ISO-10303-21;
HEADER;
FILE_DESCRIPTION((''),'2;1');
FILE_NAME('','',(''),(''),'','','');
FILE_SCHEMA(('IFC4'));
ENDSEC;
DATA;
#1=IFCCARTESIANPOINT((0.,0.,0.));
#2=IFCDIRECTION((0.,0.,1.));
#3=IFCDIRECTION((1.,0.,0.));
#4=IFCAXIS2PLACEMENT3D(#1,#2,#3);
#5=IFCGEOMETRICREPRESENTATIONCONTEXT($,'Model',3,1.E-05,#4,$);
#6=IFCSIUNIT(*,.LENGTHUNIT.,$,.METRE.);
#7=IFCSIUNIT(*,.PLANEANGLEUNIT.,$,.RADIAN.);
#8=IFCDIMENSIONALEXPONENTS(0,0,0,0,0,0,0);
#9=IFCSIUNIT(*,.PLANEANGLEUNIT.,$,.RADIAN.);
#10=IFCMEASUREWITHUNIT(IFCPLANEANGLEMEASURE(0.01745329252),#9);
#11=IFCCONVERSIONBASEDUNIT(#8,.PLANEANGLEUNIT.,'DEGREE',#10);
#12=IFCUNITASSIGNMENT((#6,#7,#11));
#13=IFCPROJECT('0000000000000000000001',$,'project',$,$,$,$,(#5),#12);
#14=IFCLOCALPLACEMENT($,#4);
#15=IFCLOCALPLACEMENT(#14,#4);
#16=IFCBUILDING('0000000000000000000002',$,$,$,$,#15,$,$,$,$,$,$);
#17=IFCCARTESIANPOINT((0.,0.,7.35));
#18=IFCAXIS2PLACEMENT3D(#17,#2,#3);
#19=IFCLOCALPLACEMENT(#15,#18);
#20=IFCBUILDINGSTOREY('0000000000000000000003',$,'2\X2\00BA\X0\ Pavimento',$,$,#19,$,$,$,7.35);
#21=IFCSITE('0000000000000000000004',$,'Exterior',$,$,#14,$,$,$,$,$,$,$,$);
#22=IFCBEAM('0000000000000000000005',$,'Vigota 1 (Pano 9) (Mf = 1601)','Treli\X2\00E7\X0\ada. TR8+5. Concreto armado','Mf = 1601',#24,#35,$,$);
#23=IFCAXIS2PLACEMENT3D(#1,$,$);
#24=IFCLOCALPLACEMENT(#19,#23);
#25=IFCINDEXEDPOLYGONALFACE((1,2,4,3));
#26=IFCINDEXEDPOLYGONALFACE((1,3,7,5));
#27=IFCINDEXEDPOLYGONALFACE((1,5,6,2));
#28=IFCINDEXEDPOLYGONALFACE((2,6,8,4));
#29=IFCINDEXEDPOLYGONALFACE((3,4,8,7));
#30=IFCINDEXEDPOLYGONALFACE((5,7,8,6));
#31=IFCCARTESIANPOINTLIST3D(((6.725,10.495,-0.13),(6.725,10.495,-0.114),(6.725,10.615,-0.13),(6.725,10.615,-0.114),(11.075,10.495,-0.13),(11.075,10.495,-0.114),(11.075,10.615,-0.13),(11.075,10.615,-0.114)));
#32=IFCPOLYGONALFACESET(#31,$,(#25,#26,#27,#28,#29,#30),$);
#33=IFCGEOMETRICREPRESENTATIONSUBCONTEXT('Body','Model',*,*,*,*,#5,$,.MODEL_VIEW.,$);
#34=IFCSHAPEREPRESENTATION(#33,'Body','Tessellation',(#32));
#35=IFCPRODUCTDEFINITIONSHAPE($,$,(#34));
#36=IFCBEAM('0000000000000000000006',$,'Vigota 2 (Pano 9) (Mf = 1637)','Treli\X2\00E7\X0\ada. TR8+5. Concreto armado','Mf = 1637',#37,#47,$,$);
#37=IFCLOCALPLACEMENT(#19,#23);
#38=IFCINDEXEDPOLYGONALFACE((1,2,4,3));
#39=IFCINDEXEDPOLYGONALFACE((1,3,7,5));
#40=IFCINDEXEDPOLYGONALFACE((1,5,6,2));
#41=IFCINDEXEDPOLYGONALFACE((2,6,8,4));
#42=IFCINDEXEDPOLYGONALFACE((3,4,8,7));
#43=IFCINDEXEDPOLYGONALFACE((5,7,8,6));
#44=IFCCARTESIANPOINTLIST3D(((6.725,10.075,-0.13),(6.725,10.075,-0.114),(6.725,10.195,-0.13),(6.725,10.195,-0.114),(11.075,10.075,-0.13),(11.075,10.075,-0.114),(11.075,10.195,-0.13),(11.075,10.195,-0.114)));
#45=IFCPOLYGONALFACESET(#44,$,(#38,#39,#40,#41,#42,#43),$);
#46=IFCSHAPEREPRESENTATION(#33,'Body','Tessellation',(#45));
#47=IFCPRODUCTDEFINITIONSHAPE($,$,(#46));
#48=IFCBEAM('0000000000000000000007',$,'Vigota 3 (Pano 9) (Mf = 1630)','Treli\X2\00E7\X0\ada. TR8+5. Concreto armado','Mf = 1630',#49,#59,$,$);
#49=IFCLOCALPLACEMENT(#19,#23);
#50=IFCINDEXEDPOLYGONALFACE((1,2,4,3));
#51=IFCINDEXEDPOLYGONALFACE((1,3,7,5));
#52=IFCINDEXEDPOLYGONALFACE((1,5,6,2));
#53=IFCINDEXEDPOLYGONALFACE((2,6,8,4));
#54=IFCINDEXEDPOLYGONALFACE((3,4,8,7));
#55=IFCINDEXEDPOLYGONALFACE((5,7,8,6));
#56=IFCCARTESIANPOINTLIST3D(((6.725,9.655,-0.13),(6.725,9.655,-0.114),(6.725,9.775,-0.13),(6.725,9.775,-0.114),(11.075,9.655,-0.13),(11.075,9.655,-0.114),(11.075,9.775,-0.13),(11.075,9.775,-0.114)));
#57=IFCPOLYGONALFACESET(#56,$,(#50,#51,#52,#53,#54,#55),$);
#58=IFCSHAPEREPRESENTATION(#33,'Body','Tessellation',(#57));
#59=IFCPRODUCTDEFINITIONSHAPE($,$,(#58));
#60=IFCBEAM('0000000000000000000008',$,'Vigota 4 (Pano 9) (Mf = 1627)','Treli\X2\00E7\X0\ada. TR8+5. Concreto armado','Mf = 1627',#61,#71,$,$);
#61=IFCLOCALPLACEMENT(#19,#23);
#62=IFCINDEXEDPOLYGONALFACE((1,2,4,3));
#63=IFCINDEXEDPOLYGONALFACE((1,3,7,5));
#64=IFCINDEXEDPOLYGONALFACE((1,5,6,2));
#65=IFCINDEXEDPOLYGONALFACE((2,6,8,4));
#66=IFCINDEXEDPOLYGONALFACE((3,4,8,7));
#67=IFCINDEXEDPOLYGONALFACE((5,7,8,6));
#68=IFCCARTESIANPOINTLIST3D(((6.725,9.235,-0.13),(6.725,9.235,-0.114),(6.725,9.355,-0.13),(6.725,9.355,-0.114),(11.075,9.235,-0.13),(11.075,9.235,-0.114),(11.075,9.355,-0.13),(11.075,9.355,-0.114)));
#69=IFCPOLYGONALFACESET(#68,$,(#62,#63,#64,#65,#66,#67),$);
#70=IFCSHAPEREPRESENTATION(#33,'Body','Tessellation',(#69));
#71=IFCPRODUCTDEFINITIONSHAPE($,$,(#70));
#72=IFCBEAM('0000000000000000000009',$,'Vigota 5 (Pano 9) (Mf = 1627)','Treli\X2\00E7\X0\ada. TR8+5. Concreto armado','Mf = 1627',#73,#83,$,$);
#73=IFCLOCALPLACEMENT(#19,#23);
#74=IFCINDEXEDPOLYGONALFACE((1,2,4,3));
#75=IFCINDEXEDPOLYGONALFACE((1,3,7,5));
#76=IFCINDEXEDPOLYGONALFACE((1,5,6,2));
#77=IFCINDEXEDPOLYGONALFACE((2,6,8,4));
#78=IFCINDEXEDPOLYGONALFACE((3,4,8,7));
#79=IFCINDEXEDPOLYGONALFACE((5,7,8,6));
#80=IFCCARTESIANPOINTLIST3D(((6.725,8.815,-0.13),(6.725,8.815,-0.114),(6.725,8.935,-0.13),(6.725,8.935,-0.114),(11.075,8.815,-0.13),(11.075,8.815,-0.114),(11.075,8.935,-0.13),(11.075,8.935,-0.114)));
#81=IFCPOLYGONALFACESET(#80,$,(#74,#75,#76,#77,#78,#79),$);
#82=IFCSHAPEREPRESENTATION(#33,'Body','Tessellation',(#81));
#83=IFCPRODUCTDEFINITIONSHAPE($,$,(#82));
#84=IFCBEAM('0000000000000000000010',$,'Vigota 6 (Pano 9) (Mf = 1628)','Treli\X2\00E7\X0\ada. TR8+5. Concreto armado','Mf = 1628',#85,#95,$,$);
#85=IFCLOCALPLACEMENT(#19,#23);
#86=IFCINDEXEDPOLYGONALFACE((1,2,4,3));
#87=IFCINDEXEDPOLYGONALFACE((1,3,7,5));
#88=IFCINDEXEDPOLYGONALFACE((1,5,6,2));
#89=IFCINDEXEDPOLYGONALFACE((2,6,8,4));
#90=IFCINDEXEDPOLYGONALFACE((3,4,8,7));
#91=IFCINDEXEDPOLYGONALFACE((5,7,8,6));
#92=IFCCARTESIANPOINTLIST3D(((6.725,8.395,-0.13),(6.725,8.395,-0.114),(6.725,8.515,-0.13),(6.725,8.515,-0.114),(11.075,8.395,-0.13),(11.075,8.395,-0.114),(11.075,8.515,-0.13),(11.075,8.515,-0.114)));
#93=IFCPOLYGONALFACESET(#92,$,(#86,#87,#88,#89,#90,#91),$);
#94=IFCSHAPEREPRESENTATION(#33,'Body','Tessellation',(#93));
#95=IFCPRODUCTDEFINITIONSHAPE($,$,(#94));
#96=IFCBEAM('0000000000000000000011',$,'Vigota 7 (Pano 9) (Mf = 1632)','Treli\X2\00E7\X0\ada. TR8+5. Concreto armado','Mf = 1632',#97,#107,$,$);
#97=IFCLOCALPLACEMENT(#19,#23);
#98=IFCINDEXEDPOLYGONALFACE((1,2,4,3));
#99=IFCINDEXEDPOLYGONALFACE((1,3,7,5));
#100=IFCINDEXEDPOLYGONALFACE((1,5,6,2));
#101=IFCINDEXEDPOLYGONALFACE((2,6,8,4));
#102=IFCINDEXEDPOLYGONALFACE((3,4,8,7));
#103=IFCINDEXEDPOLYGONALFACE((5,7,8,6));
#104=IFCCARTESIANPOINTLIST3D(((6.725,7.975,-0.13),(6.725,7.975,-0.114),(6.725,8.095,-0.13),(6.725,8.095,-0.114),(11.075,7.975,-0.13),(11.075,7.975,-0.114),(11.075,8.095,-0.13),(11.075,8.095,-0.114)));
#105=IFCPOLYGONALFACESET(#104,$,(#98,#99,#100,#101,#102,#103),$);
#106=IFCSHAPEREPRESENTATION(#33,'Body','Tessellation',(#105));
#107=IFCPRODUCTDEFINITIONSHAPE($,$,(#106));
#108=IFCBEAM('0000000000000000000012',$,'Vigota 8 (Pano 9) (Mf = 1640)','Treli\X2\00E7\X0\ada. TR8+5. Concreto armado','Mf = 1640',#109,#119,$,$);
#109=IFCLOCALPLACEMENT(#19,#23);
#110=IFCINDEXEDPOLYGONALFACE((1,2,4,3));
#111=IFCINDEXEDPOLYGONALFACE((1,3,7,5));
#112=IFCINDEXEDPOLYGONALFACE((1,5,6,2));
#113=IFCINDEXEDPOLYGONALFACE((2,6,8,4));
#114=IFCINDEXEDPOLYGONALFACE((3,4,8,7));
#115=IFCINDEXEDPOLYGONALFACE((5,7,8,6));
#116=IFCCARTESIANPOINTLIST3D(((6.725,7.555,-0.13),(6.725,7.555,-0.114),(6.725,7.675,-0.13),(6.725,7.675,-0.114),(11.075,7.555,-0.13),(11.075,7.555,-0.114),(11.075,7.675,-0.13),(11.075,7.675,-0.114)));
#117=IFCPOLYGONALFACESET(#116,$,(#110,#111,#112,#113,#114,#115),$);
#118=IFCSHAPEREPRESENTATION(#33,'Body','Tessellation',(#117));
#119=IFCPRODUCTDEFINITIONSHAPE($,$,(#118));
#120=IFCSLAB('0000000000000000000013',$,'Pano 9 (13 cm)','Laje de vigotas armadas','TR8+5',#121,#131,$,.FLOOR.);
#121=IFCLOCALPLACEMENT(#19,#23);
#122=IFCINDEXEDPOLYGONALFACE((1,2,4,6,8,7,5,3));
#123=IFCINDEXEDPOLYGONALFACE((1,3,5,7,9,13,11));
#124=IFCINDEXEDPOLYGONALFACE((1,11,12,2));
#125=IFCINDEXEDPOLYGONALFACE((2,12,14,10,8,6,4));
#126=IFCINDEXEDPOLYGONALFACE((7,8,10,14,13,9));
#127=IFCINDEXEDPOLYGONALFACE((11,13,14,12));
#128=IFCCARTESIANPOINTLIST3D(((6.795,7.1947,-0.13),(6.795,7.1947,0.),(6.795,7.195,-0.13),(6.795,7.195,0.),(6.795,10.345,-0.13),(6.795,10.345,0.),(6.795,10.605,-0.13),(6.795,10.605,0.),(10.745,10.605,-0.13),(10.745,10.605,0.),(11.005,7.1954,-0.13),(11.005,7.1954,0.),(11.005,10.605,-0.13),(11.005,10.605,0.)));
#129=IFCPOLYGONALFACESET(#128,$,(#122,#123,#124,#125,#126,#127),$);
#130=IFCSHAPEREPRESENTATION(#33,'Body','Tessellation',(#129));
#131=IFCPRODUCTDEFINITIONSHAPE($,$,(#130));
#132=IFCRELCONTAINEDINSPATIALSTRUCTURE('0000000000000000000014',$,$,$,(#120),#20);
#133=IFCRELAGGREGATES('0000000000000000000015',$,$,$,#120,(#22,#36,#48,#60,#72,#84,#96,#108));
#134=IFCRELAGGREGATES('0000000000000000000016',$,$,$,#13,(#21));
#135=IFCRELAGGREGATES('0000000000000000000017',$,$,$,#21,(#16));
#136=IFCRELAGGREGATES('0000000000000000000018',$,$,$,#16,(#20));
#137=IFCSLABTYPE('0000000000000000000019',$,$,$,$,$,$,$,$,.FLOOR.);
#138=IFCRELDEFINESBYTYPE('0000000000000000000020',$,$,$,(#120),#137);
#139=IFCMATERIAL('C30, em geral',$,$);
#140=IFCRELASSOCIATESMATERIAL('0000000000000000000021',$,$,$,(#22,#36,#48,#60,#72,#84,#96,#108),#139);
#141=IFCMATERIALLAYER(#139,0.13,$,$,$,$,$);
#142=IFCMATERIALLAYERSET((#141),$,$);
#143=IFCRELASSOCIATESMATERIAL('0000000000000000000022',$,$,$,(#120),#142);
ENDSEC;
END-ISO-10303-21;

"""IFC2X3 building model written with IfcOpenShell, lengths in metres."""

from ifc_helpers import new_model, entity, si_unit, converted_unit, frame, origin_with_axes, place, context, subcontext, project, spatial, polyline, outline, extrude, material, layer, layer_set, layer_usage, type_object, element, aggregate, save


model = new_model("IFC2X3")

# Units and contexts
model_context = context("Model", 3, precision=1e-05, world=origin_with_axes())
body_context = subcontext(model_context, "Body", "Model", "MODEL_VIEW")
ifc_project = project(units=[si_unit("LENGTHUNIT", "METRE"), si_unit("PLANEANGLEUNIT", "RADIAN"), converted_unit("PLANEANGLEUNIT", "DEGREE", entity("IfcPlaneAngleMeasure", 0.01745329252), si_unit("PLANEANGLEUNIT", "RADIAN"), dimensions=[0, 0, 0, 0, 0, 0, 0])], contexts=[model_context])

# Beams
ifc_material = material(Name="C30, em geral")
site_placement = place(None, origin_with_axes())
building_placement = place(site_placement, origin_with_axes())
storey_placement = place(building_placement, frame((0.0, 0.0, 7.35), z_axis=(0.0, 0.0, 1.0), x_axis=(1.0, 0.0, 0.0)))
beam_1_placement = place(storey_placement, frame((6.725, 10.555, -0.122), z_axis=(1.0, 0.0, 0.0), x_axis=(0.0, 1.0, 0.0)))
beam_1 = element("IfcBeam", 1, at=beam_1_placement, material=ifc_material, Name="Vigota 1 (Pano 9) (Mf = 1601)", Description="Treliçada. TR8+5. Concreto armado", ObjectType="Mf = 1601", context=body_context, shape_type="SweptSolid", body=[
    extrude(outline(polyline([(0.06, 0.008), (-0.06, 0.008), (-0.06, -0.008), (0.06, -0.008), (0.06, 0.008)])), origin_with_axes(), (0.0, 0.0, 1.0), 4.35),
])
beam_2_placement = place(storey_placement, frame((6.725, 10.135, -0.122), z_axis=(1.0, 0.0, 0.0), x_axis=(0.0, 1.0, 0.0)))
beam_2 = element("IfcBeam", 2, at=beam_2_placement, material=ifc_material, Name="Vigota 2 (Pano 9) (Mf = 1637)", Description="Treliçada. TR8+5. Concreto armado", ObjectType="Mf = 1637", context=body_context, shape_type="SweptSolid", body=[
    extrude(outline(polyline([(0.06, 0.008), (-0.06, 0.008), (-0.06, -0.008), (0.06, -0.008), (0.06, 0.008)])), origin_with_axes(), (0.0, 0.0, 1.0), 4.35),
])
beam_3_placement = place(storey_placement, frame((6.725, 9.715, -0.122), z_axis=(1.0, 0.0, 0.0), x_axis=(0.0, 1.0, 0.0)))
beam_3 = element("IfcBeam", 3, at=beam_3_placement, material=ifc_material, Name="Vigota 3 (Pano 9) (Mf = 1630)", Description="Treliçada. TR8+5. Concreto armado", ObjectType="Mf = 1630", context=body_context, shape_type="SweptSolid", body=[
    extrude(outline(polyline([(0.06, 0.008), (-0.06, 0.008), (-0.06, -0.008), (0.06, -0.008), (0.06, 0.008)])), origin_with_axes(), (0.0, 0.0, 1.0), 4.35),
])
beam_4_placement = place(storey_placement, frame((6.725, 9.295, -0.122), z_axis=(1.0, 0.0, 0.0), x_axis=(0.0, 1.0, 0.0)))
beam_4 = element("IfcBeam", 4, at=beam_4_placement, material=ifc_material, Name="Vigota 4 (Pano 9) (Mf = 1627)", Description="Treliçada. TR8+5. Concreto armado", ObjectType="Mf = 1627", context=body_context, shape_type="SweptSolid", body=[
    extrude(outline(polyline([(0.06, 0.008), (-0.06, 0.008), (-0.06, -0.008), (0.06, -0.008), (0.06, 0.008)])), origin_with_axes(), (0.0, 0.0, 1.0), 4.35),
])
beam_5_placement = place(storey_placement, frame((6.725, 8.875, -0.122), z_axis=(1.0, 0.0, 0.0), x_axis=(0.0, 1.0, 0.0)))
beam_5 = element("IfcBeam", 5, at=beam_5_placement, material=ifc_material, Name="Vigota 5 (Pano 9) (Mf = 1627)", Description="Treliçada. TR8+5. Concreto armado", ObjectType="Mf = 1627", context=body_context, shape_type="SweptSolid", body=[
    extrude(outline(polyline([(0.06, 0.008), (-0.06, 0.008), (-0.06, -0.008), (0.06, -0.008), (0.06, 0.008)])), origin_with_axes(), (0.0, 0.0, 1.0), 4.35),
])
beam_6_placement = place(storey_placement, frame((6.725, 8.455, -0.122), z_axis=(1.0, 0.0, 0.0), x_axis=(0.0, 1.0, 0.0)))
beam_6 = element("IfcBeam", 6, at=beam_6_placement, material=ifc_material, Name="Vigota 6 (Pano 9) (Mf = 1628)", Description="Treliçada. TR8+5. Concreto armado", ObjectType="Mf = 1628", context=body_context, shape_type="SweptSolid", body=[
    extrude(outline(polyline([(0.06, 0.008), (-0.06, 0.008), (-0.06, -0.008), (0.06, -0.008), (0.06, 0.008)])), origin_with_axes(), (0.0, 0.0, 1.0), 4.35),
])
beam_7_placement = place(storey_placement, frame((6.725, 8.035, -0.122), z_axis=(1.0, 0.0, 0.0), x_axis=(0.0, 1.0, 0.0)))
beam_7 = element("IfcBeam", 7, at=beam_7_placement, material=ifc_material, Name="Vigota 7 (Pano 9) (Mf = 1632)", Description="Treliçada. TR8+5. Concreto armado", ObjectType="Mf = 1632", context=body_context, shape_type="SweptSolid", body=[
    extrude(outline(polyline([(0.06, 0.008), (-0.06, 0.008), (-0.06, -0.008), (0.06, -0.008), (0.06, 0.008)])), origin_with_axes(), (0.0, 0.0, 1.0), 4.35),
])
beam_8_placement = place(storey_placement, frame((6.725, 7.615, -0.122), z_axis=(1.0, 0.0, 0.0), x_axis=(0.0, 1.0, 0.0)))
beam_8 = element("IfcBeam", 8, at=beam_8_placement, material=ifc_material, Name="Vigota 8 (Pano 9) (Mf = 1640)", Description="Treliçada. TR8+5. Concreto armado", ObjectType="Mf = 1640", context=body_context, shape_type="SweptSolid", body=[
    extrude(outline(polyline([(0.06, 0.008), (-0.06, 0.008), (-0.06, -0.008), (0.06, -0.008), (0.06, 0.008)])), origin_with_axes(), (0.0, 0.0, 1.0), 4.35),
])

# Site, building, storey
site = spatial("IfcSite", under=ifc_project, at=site_placement, Name="Exterior")
building = spatial("IfcBuilding", under=site, at=building_placement)
storey = spatial("IfcBuildingStorey", under=building, at=storey_placement, Name="2º Pavimento", Elevation=7.35)

# Slab
slab_type = type_object("IfcSlabType", PredefinedType="FLOOR")
ifc_layer_1 = layer(ifc_material, 0.13)
ifc_layer_set_1 = layer_set([ifc_layer_1])
ifc_layer_usage_1 = layer_usage(ifc_layer_set_1, "AXIS3", "POSITIVE", 0.0)
slab_1_placement = place(storey_placement, frame((0.0, 0.0, -0.13), z_axis=(0.0, 0.0, 1.0), x_axis=(1.0, 0.0, 0.0)))
slab_1 = element("IfcSlab", 9, at=slab_1_placement, inside=storey, type_object=slab_type, material=ifc_layer_usage_1, Name="Pano 9 (13 cm)", Description="Laje de vigotas armadas", ObjectType="TR8+5", PredefinedType="FLOOR", context=body_context, shape_type="SweptSolid", body=[
    extrude(outline(polyline([(11.005, 7.1954), (11.005, 10.605), (10.745, 10.605), (6.795, 10.605), (6.795, 10.345), (6.795, 7.195), (6.795, 7.1947), (11.005, 7.1954)])), origin_with_axes(), (0.0, 0.0, 1.0), 0.13),
])
aggregate(slab_1, [beam_1, beam_2, beam_3, beam_4, beam_5, beam_6, beam_7, beam_8])

save(model, "model.ifc")
